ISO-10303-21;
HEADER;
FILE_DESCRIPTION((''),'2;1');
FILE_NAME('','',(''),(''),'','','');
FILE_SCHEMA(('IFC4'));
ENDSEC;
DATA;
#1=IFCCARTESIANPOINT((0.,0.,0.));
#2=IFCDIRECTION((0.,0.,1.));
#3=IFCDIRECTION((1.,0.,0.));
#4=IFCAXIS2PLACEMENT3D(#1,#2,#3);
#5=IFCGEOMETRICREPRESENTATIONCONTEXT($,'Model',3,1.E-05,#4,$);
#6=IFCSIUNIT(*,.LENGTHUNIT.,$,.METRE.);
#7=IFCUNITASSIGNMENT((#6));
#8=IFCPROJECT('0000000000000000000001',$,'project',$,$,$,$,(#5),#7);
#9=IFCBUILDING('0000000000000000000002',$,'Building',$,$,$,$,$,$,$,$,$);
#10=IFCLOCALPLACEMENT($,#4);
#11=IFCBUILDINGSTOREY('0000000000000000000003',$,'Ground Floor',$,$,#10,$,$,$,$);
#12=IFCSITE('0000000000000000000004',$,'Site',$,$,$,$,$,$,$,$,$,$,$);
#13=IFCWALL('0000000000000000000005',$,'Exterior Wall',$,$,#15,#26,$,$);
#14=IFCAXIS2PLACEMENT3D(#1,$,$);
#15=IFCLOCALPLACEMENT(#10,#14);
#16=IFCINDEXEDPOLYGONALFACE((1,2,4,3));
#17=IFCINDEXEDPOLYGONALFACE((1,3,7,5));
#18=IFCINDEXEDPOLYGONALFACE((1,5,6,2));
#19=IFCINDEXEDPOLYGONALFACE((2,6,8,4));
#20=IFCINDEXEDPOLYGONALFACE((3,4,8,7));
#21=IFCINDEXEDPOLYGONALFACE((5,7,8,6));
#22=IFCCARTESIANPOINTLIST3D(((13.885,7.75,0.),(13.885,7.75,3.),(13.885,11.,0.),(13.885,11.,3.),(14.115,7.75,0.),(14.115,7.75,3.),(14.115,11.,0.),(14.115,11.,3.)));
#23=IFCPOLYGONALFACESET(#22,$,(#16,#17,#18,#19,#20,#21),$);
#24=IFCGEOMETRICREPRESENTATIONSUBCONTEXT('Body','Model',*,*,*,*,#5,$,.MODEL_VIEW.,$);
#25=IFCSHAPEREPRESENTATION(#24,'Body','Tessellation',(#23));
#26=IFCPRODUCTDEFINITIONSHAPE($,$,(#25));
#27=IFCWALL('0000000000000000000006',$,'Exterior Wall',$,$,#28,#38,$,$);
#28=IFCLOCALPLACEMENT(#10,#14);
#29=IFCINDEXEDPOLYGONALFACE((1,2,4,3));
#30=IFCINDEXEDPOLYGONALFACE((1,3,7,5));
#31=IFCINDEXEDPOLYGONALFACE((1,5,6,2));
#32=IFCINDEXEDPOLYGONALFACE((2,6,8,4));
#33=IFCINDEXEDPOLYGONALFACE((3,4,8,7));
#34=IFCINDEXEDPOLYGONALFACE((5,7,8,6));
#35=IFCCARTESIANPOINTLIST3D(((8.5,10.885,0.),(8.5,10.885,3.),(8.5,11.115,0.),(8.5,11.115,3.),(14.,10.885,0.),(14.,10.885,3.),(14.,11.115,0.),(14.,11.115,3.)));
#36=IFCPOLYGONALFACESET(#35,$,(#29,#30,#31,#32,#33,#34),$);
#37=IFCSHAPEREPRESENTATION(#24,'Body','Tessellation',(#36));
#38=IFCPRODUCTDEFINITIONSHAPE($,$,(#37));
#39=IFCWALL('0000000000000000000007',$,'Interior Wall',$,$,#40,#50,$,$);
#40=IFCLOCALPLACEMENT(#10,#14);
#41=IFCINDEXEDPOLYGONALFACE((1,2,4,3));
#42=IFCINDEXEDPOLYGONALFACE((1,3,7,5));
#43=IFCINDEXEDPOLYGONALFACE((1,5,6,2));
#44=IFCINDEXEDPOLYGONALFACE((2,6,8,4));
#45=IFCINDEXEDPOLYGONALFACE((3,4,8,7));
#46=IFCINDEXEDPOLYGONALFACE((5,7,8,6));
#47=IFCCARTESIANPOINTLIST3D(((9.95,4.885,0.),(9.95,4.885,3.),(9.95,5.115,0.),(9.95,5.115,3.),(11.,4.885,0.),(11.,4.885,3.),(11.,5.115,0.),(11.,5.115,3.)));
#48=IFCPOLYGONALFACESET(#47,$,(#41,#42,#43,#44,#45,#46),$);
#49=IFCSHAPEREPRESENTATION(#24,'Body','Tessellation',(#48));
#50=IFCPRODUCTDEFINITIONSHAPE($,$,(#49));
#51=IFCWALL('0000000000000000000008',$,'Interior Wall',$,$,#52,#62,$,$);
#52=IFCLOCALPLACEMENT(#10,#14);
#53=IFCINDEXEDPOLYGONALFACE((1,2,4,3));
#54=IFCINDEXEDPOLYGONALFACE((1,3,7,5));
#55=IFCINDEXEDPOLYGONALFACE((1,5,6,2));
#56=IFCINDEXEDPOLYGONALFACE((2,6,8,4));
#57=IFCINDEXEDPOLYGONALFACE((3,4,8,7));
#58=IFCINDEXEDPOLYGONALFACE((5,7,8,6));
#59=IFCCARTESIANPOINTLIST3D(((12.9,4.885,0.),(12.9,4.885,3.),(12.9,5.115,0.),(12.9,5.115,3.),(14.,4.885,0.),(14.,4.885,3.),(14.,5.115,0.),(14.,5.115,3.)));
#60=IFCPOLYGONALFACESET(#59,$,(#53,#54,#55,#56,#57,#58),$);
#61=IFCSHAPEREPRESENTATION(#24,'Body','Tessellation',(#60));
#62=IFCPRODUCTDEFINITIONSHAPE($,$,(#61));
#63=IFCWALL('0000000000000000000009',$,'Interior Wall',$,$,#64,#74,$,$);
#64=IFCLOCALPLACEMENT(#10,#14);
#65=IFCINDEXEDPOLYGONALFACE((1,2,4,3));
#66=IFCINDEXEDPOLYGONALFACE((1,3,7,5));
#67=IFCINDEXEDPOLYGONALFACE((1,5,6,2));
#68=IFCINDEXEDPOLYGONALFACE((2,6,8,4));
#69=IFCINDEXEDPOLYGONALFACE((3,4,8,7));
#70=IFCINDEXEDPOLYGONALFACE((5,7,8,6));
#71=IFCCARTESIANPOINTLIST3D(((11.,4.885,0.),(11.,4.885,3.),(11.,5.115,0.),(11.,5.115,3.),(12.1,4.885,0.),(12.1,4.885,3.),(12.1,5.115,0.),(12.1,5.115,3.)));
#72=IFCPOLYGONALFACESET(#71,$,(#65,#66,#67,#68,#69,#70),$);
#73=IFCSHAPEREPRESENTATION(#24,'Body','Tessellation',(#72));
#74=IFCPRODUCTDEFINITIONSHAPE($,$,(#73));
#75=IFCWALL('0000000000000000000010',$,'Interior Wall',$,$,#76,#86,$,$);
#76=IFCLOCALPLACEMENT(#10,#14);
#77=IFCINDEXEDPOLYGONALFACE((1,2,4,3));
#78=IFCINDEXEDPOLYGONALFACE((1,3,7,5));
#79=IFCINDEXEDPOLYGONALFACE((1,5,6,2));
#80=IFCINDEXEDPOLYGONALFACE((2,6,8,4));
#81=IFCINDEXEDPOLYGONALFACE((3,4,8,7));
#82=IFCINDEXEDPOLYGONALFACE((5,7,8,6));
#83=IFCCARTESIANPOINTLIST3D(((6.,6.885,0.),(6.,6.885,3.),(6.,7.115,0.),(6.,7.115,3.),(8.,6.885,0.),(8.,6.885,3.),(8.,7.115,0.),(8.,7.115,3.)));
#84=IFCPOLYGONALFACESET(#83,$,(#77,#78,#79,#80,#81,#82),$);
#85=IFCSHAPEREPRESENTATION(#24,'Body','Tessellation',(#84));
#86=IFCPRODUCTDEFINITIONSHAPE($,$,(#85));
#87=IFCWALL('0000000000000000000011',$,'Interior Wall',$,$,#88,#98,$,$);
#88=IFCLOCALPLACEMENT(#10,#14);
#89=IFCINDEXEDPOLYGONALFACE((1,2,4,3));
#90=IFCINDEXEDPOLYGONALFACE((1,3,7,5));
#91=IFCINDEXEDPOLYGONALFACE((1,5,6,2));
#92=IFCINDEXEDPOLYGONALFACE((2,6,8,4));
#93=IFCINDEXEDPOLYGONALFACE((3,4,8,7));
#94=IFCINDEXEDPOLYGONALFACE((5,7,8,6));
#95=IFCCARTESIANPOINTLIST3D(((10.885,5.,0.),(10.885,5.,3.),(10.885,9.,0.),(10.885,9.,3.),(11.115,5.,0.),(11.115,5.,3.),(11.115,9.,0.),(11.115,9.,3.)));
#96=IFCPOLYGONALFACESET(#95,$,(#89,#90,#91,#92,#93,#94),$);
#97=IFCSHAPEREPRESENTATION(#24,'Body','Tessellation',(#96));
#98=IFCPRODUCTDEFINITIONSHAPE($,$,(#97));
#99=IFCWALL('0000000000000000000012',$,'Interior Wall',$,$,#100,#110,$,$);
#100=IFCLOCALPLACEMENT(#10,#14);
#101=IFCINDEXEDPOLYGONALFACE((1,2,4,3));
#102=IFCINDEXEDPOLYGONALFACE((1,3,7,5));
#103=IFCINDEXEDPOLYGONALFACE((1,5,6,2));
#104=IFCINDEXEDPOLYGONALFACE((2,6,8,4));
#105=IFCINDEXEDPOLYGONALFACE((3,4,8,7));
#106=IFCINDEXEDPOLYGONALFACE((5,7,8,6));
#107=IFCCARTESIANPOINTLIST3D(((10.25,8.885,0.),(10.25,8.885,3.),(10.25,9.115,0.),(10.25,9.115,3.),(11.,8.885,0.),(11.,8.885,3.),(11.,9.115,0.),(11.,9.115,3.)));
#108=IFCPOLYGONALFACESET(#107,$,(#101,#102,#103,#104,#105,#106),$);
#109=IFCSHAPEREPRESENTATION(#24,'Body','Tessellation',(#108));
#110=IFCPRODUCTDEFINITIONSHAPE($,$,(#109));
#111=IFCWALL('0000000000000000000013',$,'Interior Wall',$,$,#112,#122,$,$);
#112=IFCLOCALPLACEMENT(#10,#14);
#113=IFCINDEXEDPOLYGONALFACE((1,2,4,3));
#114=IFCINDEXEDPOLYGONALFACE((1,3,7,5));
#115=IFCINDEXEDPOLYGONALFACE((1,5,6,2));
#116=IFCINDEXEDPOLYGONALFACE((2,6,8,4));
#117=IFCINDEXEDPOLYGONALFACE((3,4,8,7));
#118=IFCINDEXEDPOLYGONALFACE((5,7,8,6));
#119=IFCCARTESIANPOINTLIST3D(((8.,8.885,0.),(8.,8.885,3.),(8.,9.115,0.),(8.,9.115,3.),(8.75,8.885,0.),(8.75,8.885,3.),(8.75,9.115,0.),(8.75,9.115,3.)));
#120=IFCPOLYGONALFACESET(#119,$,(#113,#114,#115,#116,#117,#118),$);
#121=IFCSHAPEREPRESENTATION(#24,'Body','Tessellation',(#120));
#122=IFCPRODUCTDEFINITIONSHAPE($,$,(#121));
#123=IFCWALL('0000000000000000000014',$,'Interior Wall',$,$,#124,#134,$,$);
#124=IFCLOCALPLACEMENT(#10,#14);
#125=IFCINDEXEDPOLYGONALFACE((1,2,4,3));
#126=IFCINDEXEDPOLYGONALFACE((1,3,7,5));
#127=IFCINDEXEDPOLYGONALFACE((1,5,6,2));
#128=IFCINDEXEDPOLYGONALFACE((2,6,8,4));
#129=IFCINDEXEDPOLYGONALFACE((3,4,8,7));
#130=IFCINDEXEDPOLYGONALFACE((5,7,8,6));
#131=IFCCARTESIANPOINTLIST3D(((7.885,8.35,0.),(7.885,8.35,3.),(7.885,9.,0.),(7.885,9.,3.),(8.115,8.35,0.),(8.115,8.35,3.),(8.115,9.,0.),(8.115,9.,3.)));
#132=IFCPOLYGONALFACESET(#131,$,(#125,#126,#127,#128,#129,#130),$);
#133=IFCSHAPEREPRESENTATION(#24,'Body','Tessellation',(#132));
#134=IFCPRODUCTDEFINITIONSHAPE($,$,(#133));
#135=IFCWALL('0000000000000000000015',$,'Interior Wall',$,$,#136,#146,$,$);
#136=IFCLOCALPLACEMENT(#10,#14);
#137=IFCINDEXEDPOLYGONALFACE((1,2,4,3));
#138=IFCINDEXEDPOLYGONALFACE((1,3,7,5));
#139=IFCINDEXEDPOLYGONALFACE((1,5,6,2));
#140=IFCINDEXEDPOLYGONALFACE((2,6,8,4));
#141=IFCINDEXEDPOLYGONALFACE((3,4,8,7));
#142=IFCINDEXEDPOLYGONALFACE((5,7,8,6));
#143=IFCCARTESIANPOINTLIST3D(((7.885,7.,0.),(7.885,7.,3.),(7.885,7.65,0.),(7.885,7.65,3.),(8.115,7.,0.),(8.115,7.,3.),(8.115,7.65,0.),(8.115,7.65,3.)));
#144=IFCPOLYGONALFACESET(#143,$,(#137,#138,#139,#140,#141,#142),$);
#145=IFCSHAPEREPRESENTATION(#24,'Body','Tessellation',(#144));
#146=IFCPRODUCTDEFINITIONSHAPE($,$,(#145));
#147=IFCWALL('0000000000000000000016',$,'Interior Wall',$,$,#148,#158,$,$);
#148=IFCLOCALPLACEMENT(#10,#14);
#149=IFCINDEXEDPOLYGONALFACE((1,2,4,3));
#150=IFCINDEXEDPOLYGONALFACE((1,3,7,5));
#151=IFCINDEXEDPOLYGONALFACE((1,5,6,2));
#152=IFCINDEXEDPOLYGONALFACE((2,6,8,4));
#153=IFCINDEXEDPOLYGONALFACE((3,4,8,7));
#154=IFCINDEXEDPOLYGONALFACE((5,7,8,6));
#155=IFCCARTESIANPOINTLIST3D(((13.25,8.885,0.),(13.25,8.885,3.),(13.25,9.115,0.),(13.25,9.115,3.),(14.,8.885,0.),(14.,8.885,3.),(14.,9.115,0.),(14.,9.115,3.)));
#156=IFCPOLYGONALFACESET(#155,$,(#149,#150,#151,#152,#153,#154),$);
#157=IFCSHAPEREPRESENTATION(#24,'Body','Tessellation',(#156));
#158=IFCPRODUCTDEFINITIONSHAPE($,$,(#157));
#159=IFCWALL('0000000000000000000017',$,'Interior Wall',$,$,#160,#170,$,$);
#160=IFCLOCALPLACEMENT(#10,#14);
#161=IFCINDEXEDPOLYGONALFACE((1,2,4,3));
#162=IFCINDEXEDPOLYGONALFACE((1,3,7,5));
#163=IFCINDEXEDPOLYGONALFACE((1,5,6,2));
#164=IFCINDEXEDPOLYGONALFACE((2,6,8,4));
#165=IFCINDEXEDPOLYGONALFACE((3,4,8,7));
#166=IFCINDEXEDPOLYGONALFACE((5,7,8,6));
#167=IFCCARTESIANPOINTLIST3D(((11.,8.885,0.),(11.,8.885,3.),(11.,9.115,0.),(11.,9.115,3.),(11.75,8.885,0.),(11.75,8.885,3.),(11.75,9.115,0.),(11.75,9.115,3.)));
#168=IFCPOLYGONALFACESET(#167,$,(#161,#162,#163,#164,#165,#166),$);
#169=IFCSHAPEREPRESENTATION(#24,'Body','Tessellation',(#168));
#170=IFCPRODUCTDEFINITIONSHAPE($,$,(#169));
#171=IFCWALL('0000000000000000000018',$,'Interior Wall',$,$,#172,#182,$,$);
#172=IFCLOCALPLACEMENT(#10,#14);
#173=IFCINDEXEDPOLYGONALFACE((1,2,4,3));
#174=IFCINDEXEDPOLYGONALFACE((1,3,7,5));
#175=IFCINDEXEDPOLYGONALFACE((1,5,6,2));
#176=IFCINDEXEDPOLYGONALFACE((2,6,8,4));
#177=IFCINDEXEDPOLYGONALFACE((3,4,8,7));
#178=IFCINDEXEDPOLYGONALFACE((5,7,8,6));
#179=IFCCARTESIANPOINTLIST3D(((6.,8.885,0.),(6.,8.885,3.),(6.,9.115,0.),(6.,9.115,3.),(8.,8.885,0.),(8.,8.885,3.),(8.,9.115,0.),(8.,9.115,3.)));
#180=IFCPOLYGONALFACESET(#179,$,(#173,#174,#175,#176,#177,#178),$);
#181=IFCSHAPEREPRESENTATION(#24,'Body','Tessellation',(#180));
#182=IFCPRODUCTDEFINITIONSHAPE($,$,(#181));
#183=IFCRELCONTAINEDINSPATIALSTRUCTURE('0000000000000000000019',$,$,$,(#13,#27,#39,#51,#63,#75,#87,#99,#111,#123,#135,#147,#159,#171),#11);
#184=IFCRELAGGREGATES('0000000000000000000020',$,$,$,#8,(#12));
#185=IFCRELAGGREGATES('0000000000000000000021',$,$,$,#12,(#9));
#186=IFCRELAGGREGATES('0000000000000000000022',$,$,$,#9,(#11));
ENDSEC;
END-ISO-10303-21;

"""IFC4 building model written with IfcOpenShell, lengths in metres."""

from ifc_helpers import new_model, si_unit, frame, origin_with_axes, place, context, subcontext, project, spatial, indexed_curve, outline, extrude, element, save


model = new_model("IFC4")

# Units and contexts
model_context = context("Model", 3, precision=1e-05, world=origin_with_axes())
body_context = subcontext(model_context, "Body", "Model", "MODEL_VIEW")
ifc_project = project(units=[si_unit("LENGTHUNIT", "METRE")], contexts=[model_context])

# Site, building, storey
site = spatial("IfcSite", under=ifc_project, Name="Site")
building = spatial("IfcBuilding", under=site, Name="Building")
storey_placement = place(None, origin_with_axes())
storey = spatial("IfcBuildingStorey", under=building, at=storey_placement, Name="Ground Floor")

# Walls
wall_1_placement = place(storey_placement, frame((14.0, 7.75, 0.0), z_axis=(0.0, 0.0, 1.0), x_axis=(0.0, 1.0, 0.0)))
element("IfcWall", 1, at=wall_1_placement, inside=storey, Name="Exterior Wall", context=body_context, shape_type="SweptSolid", body=[
    extrude(outline(indexed_curve([(0.0, 0.0), (0.0, 0.23), (3.25, 0.23), (3.25, 0.0), (0.0, 0.0)], self_intersect=False)), frame((0.0, -0.115, 0.0), z_axis=(0.0, 0.0, 1.0), x_axis=(1.0, 0.0, 0.0)), (0.0, 0.0, 1.0), 3.0),
])
wall_2_placement = place(storey_placement, frame((14.0, 11.0, 0.0), z_axis=(0.0, 0.0, 1.0), x_axis=(-1.0, 0.0, 0.0)))
element("IfcWall", 2, at=wall_2_placement, inside=storey, Name="Exterior Wall", context=body_context, shape_type="SweptSolid", body=[
    extrude(outline(indexed_curve([(0.0, 0.0), (0.0, 0.23), (5.5, 0.23), (5.5, 0.0), (0.0, 0.0)], self_intersect=False)), frame((0.0, -0.115, 0.0), z_axis=(0.0, 0.0, 1.0), x_axis=(1.0, 0.0, 0.0)), (0.0, 0.0, 1.0), 3.0),
])
wall_3_placement = place(storey_placement, frame((11.0, 5.0, 0.0), z_axis=(0.0, 0.0, 1.0), x_axis=(-1.0, 0.0, 0.0)))
element("IfcWall", 3, at=wall_3_placement, inside=storey, Name="Interior Wall", context=body_context, shape_type="SweptSolid", body=[
    extrude(outline(indexed_curve([(0.0, 0.0), (0.0, 0.23), (1.05, 0.23), (1.05, 0.0), (0.0, 0.0)], self_intersect=False)), frame((0.0, -0.115, 0.0), z_axis=(0.0, 0.0, 1.0), x_axis=(1.0, 0.0, 0.0)), (0.0, 0.0, 1.0), 3.0),
])
for number, where, z_axis, x_axis, name in (
    (4, (14.0, 5.0, 0.0), (0.0, 0.0, 1.0), (-1.0, 0.0, 0.0), "Interior Wall"),
    (5, (12.1, 5.0, 0.0), (0.0, 0.0, 1.0), (-1.0, 0.0, 0.0), "Interior Wall"),
):
    element("IfcWall", number, at=place(storey_placement, frame(where, z_axis=z_axis, x_axis=x_axis)), inside=storey, Name=name, context=body_context, shape_type="SweptSolid", body=[
        extrude(outline(indexed_curve([(0.0, 0.0), (0.0, 0.23), (1.1, 0.23), (1.1, 0.0), (0.0, 0.0)], self_intersect=False)), frame((0.0, -0.115, 0.0), z_axis=(0.0, 0.0, 1.0), x_axis=(1.0, 0.0, 0.0)), (0.0, 0.0, 1.0), 3.0),
    ])
wall_4_placement = place(storey_placement, frame((8.0, 7.0, 0.0), z_axis=(0.0, 0.0, 1.0), x_axis=(-1.0, 0.0, 0.0)))
element("IfcWall", 6, at=wall_4_placement, inside=storey, Name="Interior Wall", context=body_context, shape_type="SweptSolid", body=[
    extrude(outline(indexed_curve([(0.0, 0.0), (0.0, 0.23), (2.0, 0.23), (2.0, 0.0), (0.0, 0.0)], self_intersect=False)), frame((0.0, -0.115, 0.0), z_axis=(0.0, 0.0, 1.0), x_axis=(1.0, 0.0, 0.0)), (0.0, 0.0, 1.0), 3.0),
])
wall_5_placement = place(storey_placement, frame((11.0, 5.0, 0.0), z_axis=(0.0, 0.0, 1.0), x_axis=(0.0, 1.0, 0.0)))
element("IfcWall", 7, at=wall_5_placement, inside=storey, Name="Interior Wall", context=body_context, shape_type="SweptSolid", body=[
    extrude(outline(indexed_curve([(0.0, 0.0), (0.0, 0.23), (4.0, 0.23), (4.0, 0.0), (0.0, 0.0)], self_intersect=False)), frame((0.0, -0.115, 0.0), z_axis=(0.0, 0.0, 1.0), x_axis=(1.0, 0.0, 0.0)), (0.0, 0.0, 1.0), 3.0),
])
for number, where, z_axis, x_axis, name in (
    (8, (11.0, 9.0, 0.0), (0.0, 0.0, 1.0), (-1.0, 0.0, 0.0), "Interior Wall"),
    (9, (8.75, 9.0, 0.0), (0.0, 0.0, 1.0), (-1.0, 0.0, 0.0), "Interior Wall"),
):
    element("IfcWall", number, at=place(storey_placement, frame(where, z_axis=z_axis, x_axis=x_axis)), inside=storey, Name=name, context=body_context, shape_type="SweptSolid", body=[
        extrude(outline(indexed_curve([(0.0, 0.0), (0.0, 0.23), (0.75, 0.23), (0.75, 0.0), (0.0, 0.0)], self_intersect=False)), frame((0.0, -0.115, 0.0), z_axis=(0.0, 0.0, 1.0), x_axis=(1.0, 0.0, 0.0)), (0.0, 0.0, 1.0), 3.0),
    ])
for number, where, z_axis, x_axis, name in (
    (10, (8.0, 9.0, 0.0), (0.0, 0.0, 1.0), (0.0, -1.0, 0.0), "Interior Wall"),
    (11, (8.0, 7.65, 0.0), (0.0, 0.0, 1.0), (0.0, -1.0, 0.0), "Interior Wall"),
):
    element("IfcWall", number, at=place(storey_placement, frame(where, z_axis=z_axis, x_axis=x_axis)), inside=storey, Name=name, context=body_context, shape_type="SweptSolid", body=[
        extrude(outline(indexed_curve([(0.0, 0.0), (0.0, 0.23), (0.65, 0.23), (0.65, 0.0), (0.0, 0.0)], self_intersect=False)), frame((0.0, -0.115, 0.0), z_axis=(0.0, 0.0, 1.0), x_axis=(1.0, 0.0, 0.0)), (0.0, 0.0, 1.0), 3.0),
    ])
for number, where, z_axis, x_axis, name in (
    (12, (14.0, 9.0, 0.0), (0.0, 0.0, 1.0), (-1.0, 0.0, 0.0), "Interior Wall"),
    (13, (11.75, 9.0, 0.0), (0.0, 0.0, 1.0), (-1.0, 0.0, 0.0), "Interior Wall"),
):
    element("IfcWall", number, at=place(storey_placement, frame(where, z_axis=z_axis, x_axis=x_axis)), inside=storey, Name=name, context=body_context, shape_type="SweptSolid", body=[
        extrude(outline(indexed_curve([(0.0, 0.0), (0.0, 0.23), (0.75, 0.23), (0.75, 0.0), (0.0, 0.0)], self_intersect=False)), frame((0.0, -0.115, 0.0), z_axis=(0.0, 0.0, 1.0), x_axis=(1.0, 0.0, 0.0)), (0.0, 0.0, 1.0), 3.0),
    ])
wall_6_placement = place(storey_placement, frame((8.0, 9.0, 0.0), z_axis=(0.0, 0.0, 1.0), x_axis=(-1.0, 0.0, 0.0)))
element("IfcWall", 14, at=wall_6_placement, inside=storey, Name="Interior Wall", context=body_context, shape_type="SweptSolid", body=[
    extrude(outline(indexed_curve([(0.0, 0.0), (0.0, 0.23), (2.0, 0.23), (2.0, 0.0), (0.0, 0.0)], self_intersect=False)), frame((0.0, -0.115, 0.0), z_axis=(0.0, 0.0, 1.0), x_axis=(1.0, 0.0, 0.0)), (0.0, 0.0, 1.0), 3.0),
])

save(model, "model.ifc")
